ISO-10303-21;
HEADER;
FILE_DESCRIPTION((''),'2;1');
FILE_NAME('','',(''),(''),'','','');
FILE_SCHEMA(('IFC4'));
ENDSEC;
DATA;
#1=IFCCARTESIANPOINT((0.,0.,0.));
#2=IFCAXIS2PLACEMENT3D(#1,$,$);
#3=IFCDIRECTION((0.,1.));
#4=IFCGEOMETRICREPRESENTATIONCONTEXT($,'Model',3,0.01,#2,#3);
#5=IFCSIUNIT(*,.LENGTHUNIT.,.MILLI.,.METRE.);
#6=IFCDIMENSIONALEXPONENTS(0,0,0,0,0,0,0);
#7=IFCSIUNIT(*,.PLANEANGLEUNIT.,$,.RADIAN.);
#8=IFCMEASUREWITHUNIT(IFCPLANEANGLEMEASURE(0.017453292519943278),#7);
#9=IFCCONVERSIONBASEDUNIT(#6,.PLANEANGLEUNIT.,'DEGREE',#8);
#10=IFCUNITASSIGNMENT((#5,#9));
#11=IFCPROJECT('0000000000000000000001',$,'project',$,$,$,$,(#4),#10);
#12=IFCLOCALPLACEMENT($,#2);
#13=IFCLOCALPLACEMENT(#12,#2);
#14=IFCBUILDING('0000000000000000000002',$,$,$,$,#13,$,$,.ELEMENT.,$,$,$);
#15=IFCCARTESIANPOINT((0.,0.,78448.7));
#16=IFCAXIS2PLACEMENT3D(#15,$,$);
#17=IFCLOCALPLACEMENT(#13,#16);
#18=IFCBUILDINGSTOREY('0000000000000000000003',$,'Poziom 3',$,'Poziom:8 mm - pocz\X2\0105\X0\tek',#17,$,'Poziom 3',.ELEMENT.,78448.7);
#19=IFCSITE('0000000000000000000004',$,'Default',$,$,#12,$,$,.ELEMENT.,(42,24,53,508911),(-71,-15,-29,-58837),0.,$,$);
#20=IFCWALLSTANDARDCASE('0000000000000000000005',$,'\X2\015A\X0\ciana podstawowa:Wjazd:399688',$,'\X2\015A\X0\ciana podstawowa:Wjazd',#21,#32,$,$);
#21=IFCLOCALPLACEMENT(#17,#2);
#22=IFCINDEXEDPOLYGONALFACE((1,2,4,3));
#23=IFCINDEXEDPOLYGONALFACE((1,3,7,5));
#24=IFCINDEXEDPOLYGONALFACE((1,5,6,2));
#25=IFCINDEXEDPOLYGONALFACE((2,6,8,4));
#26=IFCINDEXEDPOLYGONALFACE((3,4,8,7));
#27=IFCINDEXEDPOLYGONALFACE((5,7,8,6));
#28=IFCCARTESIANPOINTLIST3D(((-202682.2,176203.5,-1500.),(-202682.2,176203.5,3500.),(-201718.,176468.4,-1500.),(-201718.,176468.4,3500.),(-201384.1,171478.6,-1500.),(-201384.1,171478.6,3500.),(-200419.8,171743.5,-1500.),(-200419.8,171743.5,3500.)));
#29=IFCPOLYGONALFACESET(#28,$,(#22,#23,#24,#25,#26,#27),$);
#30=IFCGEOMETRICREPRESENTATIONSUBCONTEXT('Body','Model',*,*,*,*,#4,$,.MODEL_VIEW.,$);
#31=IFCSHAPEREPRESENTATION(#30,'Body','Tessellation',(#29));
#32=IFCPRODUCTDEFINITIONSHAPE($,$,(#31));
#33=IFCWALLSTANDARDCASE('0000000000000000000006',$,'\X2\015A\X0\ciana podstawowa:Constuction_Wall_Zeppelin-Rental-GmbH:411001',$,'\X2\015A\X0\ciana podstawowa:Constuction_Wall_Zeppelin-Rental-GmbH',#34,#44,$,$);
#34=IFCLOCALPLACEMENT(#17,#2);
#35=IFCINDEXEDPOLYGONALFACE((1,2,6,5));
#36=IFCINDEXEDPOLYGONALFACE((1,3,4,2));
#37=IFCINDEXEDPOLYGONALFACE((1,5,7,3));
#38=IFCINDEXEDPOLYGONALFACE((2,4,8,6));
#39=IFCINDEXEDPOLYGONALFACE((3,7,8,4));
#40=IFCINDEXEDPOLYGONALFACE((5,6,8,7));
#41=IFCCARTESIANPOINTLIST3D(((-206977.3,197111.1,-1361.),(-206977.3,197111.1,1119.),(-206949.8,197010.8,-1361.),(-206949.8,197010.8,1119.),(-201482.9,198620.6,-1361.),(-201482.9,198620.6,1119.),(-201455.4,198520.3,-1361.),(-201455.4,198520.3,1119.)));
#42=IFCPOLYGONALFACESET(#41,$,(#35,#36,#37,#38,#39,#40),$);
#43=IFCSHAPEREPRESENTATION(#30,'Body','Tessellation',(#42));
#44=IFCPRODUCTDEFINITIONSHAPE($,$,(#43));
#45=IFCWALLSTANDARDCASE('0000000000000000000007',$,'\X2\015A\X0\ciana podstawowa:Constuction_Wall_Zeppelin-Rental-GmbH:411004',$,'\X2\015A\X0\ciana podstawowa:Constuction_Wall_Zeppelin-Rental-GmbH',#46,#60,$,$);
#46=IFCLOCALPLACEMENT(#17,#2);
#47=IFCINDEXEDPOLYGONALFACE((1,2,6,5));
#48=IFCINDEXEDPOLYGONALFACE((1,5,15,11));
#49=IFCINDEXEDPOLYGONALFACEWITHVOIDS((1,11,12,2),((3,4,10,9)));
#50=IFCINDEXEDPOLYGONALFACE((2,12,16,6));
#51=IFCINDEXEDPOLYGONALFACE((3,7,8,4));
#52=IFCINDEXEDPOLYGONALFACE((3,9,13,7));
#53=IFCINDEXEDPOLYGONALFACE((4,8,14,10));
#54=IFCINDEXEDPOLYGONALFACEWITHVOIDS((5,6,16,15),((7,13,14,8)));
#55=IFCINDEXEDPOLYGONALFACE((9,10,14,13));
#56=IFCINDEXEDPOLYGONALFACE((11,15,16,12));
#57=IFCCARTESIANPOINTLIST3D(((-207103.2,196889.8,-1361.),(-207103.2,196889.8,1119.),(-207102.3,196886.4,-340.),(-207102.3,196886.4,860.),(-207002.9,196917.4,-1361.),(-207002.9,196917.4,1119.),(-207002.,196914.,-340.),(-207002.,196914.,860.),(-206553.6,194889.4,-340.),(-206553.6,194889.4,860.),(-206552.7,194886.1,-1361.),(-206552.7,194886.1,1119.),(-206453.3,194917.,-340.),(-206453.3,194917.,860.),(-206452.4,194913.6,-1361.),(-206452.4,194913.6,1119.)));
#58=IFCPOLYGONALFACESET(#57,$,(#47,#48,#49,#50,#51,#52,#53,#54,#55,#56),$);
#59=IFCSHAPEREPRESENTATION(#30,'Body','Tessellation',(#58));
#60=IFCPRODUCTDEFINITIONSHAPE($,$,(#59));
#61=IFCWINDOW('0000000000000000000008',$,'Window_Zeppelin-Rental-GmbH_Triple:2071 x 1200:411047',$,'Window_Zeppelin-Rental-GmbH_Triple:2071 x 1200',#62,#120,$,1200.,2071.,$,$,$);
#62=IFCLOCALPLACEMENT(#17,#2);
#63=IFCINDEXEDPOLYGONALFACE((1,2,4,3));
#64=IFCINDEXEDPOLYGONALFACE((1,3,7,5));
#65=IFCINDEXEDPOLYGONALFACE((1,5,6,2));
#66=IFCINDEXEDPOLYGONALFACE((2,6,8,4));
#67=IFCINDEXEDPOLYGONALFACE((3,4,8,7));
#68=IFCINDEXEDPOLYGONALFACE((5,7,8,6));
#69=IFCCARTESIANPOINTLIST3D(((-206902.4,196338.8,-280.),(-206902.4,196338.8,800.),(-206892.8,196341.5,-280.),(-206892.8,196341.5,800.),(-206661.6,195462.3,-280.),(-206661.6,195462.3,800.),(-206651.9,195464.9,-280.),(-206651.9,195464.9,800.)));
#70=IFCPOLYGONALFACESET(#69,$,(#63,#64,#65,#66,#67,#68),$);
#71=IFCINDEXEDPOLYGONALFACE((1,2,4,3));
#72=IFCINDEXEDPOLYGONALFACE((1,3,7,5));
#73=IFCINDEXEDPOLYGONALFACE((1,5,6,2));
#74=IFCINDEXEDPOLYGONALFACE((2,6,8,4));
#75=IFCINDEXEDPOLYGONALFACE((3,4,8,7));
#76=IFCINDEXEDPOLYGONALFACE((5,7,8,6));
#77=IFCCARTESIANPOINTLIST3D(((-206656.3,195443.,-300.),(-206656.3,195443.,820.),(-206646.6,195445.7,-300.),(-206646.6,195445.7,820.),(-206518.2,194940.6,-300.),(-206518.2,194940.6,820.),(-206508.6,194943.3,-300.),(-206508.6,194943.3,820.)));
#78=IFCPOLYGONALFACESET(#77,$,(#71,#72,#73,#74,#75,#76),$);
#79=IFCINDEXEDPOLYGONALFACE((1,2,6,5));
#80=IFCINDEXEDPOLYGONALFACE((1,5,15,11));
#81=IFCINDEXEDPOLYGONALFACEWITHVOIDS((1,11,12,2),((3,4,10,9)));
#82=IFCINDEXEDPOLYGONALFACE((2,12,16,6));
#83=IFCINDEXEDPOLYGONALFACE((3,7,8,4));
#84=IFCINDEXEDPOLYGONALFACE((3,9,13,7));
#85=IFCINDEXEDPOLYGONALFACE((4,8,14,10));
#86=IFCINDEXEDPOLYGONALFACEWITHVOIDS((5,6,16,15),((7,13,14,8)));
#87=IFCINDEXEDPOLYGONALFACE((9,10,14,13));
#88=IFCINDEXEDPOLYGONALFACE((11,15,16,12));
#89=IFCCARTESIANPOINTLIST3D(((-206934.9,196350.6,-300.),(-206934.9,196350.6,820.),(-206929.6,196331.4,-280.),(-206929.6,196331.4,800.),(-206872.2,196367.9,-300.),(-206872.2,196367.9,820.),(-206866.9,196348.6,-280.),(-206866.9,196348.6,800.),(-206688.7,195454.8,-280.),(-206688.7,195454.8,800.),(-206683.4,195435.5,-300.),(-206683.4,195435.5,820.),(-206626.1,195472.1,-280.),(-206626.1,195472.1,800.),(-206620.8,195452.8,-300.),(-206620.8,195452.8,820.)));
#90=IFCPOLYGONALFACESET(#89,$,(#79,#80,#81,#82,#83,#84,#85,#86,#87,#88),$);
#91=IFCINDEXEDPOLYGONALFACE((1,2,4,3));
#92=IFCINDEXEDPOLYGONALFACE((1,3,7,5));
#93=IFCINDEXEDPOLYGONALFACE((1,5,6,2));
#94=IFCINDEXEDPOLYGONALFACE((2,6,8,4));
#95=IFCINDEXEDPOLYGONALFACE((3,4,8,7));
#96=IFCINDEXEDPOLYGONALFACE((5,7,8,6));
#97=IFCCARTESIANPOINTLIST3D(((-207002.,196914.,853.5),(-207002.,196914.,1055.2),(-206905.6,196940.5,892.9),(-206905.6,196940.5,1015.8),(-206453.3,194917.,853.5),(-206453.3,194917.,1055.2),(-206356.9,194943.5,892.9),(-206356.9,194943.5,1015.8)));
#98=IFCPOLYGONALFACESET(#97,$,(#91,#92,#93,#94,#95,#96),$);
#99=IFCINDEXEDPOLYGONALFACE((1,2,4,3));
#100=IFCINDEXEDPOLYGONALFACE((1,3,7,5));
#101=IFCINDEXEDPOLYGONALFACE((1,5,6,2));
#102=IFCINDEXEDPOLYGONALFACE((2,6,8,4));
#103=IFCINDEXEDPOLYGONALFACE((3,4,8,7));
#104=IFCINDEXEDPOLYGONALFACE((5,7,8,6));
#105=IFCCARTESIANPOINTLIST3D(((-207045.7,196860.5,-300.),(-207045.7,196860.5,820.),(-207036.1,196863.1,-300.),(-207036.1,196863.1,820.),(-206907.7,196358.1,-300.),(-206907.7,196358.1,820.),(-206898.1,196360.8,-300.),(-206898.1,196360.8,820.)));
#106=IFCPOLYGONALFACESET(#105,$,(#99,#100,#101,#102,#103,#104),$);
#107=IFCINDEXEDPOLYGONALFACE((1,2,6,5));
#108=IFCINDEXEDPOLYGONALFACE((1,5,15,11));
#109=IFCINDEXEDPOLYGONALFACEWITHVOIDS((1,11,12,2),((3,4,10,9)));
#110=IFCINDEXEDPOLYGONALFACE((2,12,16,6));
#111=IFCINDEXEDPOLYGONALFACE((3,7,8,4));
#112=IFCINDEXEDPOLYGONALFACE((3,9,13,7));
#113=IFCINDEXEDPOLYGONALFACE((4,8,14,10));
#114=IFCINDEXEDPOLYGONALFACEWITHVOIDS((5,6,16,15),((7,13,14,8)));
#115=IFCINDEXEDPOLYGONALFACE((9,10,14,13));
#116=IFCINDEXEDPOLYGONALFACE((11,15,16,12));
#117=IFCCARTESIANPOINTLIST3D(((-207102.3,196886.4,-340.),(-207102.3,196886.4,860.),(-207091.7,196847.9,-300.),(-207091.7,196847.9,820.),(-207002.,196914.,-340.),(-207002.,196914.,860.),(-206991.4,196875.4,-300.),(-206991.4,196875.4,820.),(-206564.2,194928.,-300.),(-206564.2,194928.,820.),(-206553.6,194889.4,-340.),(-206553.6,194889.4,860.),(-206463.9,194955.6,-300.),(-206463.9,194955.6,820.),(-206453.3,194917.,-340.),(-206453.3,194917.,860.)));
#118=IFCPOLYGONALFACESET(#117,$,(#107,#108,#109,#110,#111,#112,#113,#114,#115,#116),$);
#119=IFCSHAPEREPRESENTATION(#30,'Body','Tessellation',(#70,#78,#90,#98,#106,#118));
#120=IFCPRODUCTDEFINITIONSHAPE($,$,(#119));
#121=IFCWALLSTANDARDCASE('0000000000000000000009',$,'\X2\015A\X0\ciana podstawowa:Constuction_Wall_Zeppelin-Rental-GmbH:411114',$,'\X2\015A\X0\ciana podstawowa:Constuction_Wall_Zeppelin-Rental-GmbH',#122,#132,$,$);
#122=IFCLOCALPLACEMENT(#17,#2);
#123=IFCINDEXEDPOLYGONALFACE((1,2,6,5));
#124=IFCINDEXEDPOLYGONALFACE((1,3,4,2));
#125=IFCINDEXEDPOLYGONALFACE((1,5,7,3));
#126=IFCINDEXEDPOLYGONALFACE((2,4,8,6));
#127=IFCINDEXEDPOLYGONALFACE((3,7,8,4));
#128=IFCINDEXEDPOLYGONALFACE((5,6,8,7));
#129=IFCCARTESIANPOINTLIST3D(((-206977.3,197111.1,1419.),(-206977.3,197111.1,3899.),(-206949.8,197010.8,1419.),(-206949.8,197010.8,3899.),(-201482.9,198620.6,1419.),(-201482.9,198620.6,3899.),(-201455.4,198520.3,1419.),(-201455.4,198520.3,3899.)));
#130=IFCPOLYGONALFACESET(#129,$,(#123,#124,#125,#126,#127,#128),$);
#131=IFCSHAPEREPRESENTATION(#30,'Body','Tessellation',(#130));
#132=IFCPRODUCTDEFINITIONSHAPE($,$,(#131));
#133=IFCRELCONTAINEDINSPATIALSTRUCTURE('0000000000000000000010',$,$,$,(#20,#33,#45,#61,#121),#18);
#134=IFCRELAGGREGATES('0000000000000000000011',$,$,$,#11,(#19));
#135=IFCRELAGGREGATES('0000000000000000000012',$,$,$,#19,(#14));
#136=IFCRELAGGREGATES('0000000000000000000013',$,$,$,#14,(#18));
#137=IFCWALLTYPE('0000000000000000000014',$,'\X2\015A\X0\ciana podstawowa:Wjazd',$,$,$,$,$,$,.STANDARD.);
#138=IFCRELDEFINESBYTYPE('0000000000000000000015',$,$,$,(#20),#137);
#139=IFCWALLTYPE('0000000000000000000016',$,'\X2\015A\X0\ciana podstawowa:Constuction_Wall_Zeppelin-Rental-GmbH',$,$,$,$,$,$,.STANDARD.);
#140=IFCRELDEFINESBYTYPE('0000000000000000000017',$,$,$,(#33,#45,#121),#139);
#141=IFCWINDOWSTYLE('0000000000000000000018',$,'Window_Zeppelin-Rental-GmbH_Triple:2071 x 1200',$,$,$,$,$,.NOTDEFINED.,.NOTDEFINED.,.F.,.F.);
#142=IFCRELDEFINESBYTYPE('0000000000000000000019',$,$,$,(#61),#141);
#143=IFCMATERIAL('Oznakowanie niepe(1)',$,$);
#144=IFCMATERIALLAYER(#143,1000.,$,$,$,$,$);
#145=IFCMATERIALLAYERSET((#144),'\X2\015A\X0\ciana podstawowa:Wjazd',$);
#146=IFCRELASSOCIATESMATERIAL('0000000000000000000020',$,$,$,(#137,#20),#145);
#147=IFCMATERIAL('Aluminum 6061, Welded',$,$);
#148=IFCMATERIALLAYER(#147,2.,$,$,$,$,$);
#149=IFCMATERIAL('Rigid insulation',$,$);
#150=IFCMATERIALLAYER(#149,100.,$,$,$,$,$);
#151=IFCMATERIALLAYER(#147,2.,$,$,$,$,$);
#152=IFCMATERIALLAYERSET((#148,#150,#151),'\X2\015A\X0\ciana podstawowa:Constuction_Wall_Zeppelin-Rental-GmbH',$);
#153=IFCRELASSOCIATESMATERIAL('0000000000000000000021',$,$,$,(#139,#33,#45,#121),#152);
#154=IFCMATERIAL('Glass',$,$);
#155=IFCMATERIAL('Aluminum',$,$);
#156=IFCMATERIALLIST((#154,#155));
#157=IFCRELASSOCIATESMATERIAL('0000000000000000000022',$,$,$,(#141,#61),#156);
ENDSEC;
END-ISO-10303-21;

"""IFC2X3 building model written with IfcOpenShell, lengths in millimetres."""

from ifc_helpers import new_model, entity, si_unit, converted_unit, direction, frame, frame_2d, origin, origin_2d_with_axis, place, context, subcontext, project, spatial, polyline, rectangle, outline, extrude, source, transform, mapped, material, material_list, layer, layer_set, layer_usage, type_object, type_shapes, element, fill, save


model = new_model("IFC2X3")

# Units and contexts
model_context = context("Model", 3, precision=0.01, world=origin(), true_north=direction((0.0, 1.0)))
body_context = subcontext(model_context, "Body", "Model", "MODEL_VIEW")
ifc_project = project(units=[si_unit("LENGTHUNIT", "METRE", prefix="MILLI"), converted_unit("PLANEANGLEUNIT", "DEGREE", entity("IfcPlaneAngleMeasure", 0.017453292519943278), si_unit("PLANEANGLEUNIT", "RADIAN"), dimensions=[0, 0, 0, 0, 0, 0, 0])], contexts=[model_context])

# Site, building, storey
site_placement = place(None, origin())
site = spatial("IfcSite", under=ifc_project, at=site_placement, Name="Default", CompositionType="ELEMENT", RefLatitude=(42, 24, 53, 508911), RefLongitude=(-71, -15, -29, -58837), RefElevation=0.0)
building_placement = place(site_placement, origin())
building = spatial("IfcBuilding", under=site, at=building_placement, CompositionType="ELEMENT")
storey_placement = place(building_placement, frame((0.0, 0.0, 78448.7)))
storey = spatial("IfcBuildingStorey", under=building, at=storey_placement, Name="Poziom 3", ObjectType="Poziom:8 mm - początek", LongName="Poziom 3", CompositionType="ELEMENT", Elevation=78448.7)

# Walls
ifc_material_1 = material(Name="Oznakowanie niepe(1)")
ifc_layer_1 = layer(ifc_material_1, 1000.0)
ifc_layer_set_1 = layer_set([ifc_layer_1], Name="Ściana podstawowa:Wjazd")
ifc_layer_usage_1 = layer_usage(ifc_layer_set_1, "AXIS2", "NEGATIVE", 500.0)
wall_type_1 = type_object("IfcWallType", Name="Ściana podstawowa:Wjazd", PredefinedType="STANDARD", material=ifc_layer_set_1)
wall_1_placement = place(storey_placement, frame((-202200.1, 176336.0, -1500.0), z_axis=(0.0, 0.0, 1.0), x_axis=(0.264931, -0.964267, 0.0)))
element("IfcWallStandardCase", 1, at=wall_1_placement, inside=storey, type_object=wall_type_1, material=ifc_layer_usage_1, Name="Ściana podstawowa:Wjazd:399688", ObjectType="Ściana podstawowa:Wjazd", context=body_context, shape_type="SweptSolid", body=[
    extrude(rectangle(XDim=4900.0, YDim=1000.0, at=frame_2d((2450.0, 0.0), x_axis=(-1.0, 0.0))), origin(), (0.0, 0.0, 1.0), 5000.0),
])
ifc_material_2 = material(Name="Aluminum 6061, Welded")
ifc_layer_2 = layer(ifc_material_2, 2.0)
ifc_material_3 = material(Name="Rigid insulation")
ifc_layer_3 = layer(ifc_material_3, 100.0)
ifc_layer_4 = layer(ifc_material_2, 2.0)
ifc_layer_set_2 = layer_set([ifc_layer_2, ifc_layer_3, ifc_layer_4], Name="Ściana podstawowa:Constuction_Wall_Zeppelin-Rental-GmbH")
ifc_layer_usage_2 = layer_usage(ifc_layer_set_2, "AXIS2", "NEGATIVE", 52.0)
wall_type_2 = type_object("IfcWallType", Name="Ściana podstawowa:Constuction_Wall_Zeppelin-Rental-GmbH", PredefinedType="STANDARD", material=ifc_layer_set_2)
wall_2_placement = place(storey_placement, frame((-206963.6, 197060.9, -1361.0), z_axis=(0.0, 0.0, 1.0), x_axis=(0.964267, 0.264931, 0.0)))
element("IfcWallStandardCase", 2, at=wall_2_placement, inside=storey, type_object=wall_type_2, material=ifc_layer_usage_2, Name="Ściana podstawowa:Constuction_Wall_Zeppelin-Rental-GmbH:411001", ObjectType="Ściana podstawowa:Constuction_Wall_Zeppelin-Rental-GmbH", context=body_context, shape_type="SweptSolid", body=[
    extrude(rectangle(XDim=5698.0, YDim=104.0, at=frame_2d((2849.0, 0.0), x_axis=(-1.0, 0.0))), origin(), (0.0, 0.0, 1.0), 2480.0),
])

# Wall, opening, window
ifc_layer_usage_3 = layer_usage(ifc_layer_set_2, "AXIS2", "NEGATIVE", 52.0)
wall_3_placement = place(storey_placement, frame((-206502.5, 194899.8, -1361.0), z_axis=(0.0, 0.0, 1.0), x_axis=(-0.264931, 0.964267, 0.0)))
wall_3 = element("IfcWallStandardCase", 3, at=wall_3_placement, inside=storey, type_object=wall_type_2, material=ifc_layer_usage_3, Name="Ściana podstawowa:Constuction_Wall_Zeppelin-Rental-GmbH:411004", ObjectType="Ściana podstawowa:Constuction_Wall_Zeppelin-Rental-GmbH", context=body_context, shape_type="SweptSolid", body=[
    extrude(rectangle(XDim=2078.0, YDim=104.0, at=frame_2d((1039.0, 0.0), x_axis=(-1.0, 0.0))), origin(), (0.0, 0.0, 1.0), 2480.0),
])
opening_1_placement = place(wall_3_placement, frame((3.5, -52.0, 1021.0)))
opening_1 = element("IfcOpeningElement", 4, at=opening_1_placement, cuts=wall_3, ObjectType="Opening", context=body_context, shape_type="SweptSolid", body=[
    extrude(rectangle(XDim=1200.0, YDim=2071.0, at=frame_2d((600.0, 1035.5), x_axis=(1.0, 0.0))), frame((0.0, 0.0, 0.0), z_axis=(0.0, 1.0, 0.0), x_axis=(0.0, 0.0, 1.0)), (0.0, 0.0, 1.0), 104.0),
])
ifc_material_4 = material(Name="Glass")
ifc_material_5 = material(Name="Aluminum")
ifc_material_list = material_list([ifc_material_4, ifc_material_5])
window_style = type_object("IfcWindowStyle", Name="Window_Zeppelin-Rental-GmbH_Triple:2071 x 1200", ConstructionType="NOTDEFINED", OperationType="NOTDEFINED", ParameterTakesPrecedence=False, Sizeable=False, material=ifc_material_list)
shared_shape_1 = source(origin(), body_context, "Body", "SweptSolid", [
    extrude(rectangle(XDim=10.0, YDim=909.0, at=origin_2d_with_axis()), frame((1035.5, 52.7, 60.0), z_axis=(0.0, 0.0, 1.0), x_axis=(0.0, -1.0, 0.0)), (0.0, 0.0, 1.0), 1080.0),
    extrude(rectangle(XDim=521.0, YDim=10.0, at=frame_2d((0.0, 0.0), x_axis=(1.0, 0.0))), frame((300.5, 52.7, 40.0), z_axis=(0.0, 0.0, 1.0), x_axis=(-1.0, 0.0, 0.0)), (0.0, 0.0, 1.0), 1120.0),
    extrude(outline(polyline([(-474.5, -560.0), (474.5, -560.0), (474.5, 560.0), (-474.5, 560.0), (-474.5, -560.0)]), holes=[polyline([(-454.5, 540.0), (454.5, 540.0), (454.5, -540.0), (-454.5, -540.0), (-454.5, 540.0)])]), frame((1035.5, 85.8, 600.0), z_axis=(0.0, -1.0, 0.0), x_axis=(1.0, 0.0, 0.0)), (0.0, 0.0, 1.0), 65.0),
    extrude(outline(polyline([(-24.0, -75.5), (83.5, -75.5), (9.6, 112.1), (-69.0, 38.9), (-24.0, -75.5)])), frame((2071.0, -48.7, 1294.4), z_axis=(-1.0, 0.0, 0.0), x_axis=(0.0, 0.930458, 0.366398)), (0.0, 0.0, 1.0), 2071.0),
    extrude(rectangle(XDim=10.0, YDim=521.0, at=frame_2d((0.0, 0.0), x_axis=(1.0, 0.0))), frame((1770.5, 52.7, 40.0), z_axis=(0.0, 0.0, 1.0), x_axis=(0.0, -1.0, 0.0)), (0.0, 0.0, 1.0), 1120.0),
    extrude(outline(polyline([(-1035.5, -600.0), (1035.5, -600.0), (1035.5, 600.0), (-1035.5, 600.0), (-1035.5, -600.0)]), holes=[polyline([(-995.5, 560.0), (995.5, 560.0), (995.5, -560.0), (-995.5, -560.0), (-995.5, 560.0)])]), frame((1035.5, 105.3, 600.0), z_axis=(0.0, -1.0, 0.0), x_axis=(1.0, 0.0, 0.0)), (0.0, 0.0, 1.0), 104.0),
])
type_shapes(window_style, [shared_shape_1])
window_1_placement = place(opening_1_placement, frame((0.0, -1.3, 0.0)))
window_1 = element("IfcWindow", 5, at=window_1_placement, inside=storey, type_object=window_style, material=ifc_material_list, Name="Window_Zeppelin-Rental-GmbH_Triple:2071 x 1200:411047", ObjectType="Window_Zeppelin-Rental-GmbH_Triple:2071 x 1200", OverallHeight=1200.0, OverallWidth=2071.0, context=body_context, shape_type="MappedRepresentation", body=[
    mapped(shared_shape_1, transform((0.0, 0.0, 0.0), scale=1.0)),
])
fill(opening_1, window_1)

# Wall
ifc_layer_usage_4 = layer_usage(ifc_layer_set_2, "AXIS2", "NEGATIVE", 52.0)
wall_4_placement = place(storey_placement, frame((-206963.6, 197060.9, 1419.0), z_axis=(0.0, 0.0, 1.0), x_axis=(0.964267, 0.264931, 0.0)))
element("IfcWallStandardCase", 6, at=wall_4_placement, inside=storey, type_object=wall_type_2, material=ifc_layer_usage_4, Name="Ściana podstawowa:Constuction_Wall_Zeppelin-Rental-GmbH:411114", ObjectType="Ściana podstawowa:Constuction_Wall_Zeppelin-Rental-GmbH", context=body_context, shape_type="SweptSolid", body=[
    extrude(rectangle(XDim=5698.0, YDim=104.0, at=frame_2d((2849.0, 0.0), x_axis=(-1.0, 0.0))), origin(), (0.0, 0.0, 1.0), 2480.0),
])

save(model, "model.ifc")
